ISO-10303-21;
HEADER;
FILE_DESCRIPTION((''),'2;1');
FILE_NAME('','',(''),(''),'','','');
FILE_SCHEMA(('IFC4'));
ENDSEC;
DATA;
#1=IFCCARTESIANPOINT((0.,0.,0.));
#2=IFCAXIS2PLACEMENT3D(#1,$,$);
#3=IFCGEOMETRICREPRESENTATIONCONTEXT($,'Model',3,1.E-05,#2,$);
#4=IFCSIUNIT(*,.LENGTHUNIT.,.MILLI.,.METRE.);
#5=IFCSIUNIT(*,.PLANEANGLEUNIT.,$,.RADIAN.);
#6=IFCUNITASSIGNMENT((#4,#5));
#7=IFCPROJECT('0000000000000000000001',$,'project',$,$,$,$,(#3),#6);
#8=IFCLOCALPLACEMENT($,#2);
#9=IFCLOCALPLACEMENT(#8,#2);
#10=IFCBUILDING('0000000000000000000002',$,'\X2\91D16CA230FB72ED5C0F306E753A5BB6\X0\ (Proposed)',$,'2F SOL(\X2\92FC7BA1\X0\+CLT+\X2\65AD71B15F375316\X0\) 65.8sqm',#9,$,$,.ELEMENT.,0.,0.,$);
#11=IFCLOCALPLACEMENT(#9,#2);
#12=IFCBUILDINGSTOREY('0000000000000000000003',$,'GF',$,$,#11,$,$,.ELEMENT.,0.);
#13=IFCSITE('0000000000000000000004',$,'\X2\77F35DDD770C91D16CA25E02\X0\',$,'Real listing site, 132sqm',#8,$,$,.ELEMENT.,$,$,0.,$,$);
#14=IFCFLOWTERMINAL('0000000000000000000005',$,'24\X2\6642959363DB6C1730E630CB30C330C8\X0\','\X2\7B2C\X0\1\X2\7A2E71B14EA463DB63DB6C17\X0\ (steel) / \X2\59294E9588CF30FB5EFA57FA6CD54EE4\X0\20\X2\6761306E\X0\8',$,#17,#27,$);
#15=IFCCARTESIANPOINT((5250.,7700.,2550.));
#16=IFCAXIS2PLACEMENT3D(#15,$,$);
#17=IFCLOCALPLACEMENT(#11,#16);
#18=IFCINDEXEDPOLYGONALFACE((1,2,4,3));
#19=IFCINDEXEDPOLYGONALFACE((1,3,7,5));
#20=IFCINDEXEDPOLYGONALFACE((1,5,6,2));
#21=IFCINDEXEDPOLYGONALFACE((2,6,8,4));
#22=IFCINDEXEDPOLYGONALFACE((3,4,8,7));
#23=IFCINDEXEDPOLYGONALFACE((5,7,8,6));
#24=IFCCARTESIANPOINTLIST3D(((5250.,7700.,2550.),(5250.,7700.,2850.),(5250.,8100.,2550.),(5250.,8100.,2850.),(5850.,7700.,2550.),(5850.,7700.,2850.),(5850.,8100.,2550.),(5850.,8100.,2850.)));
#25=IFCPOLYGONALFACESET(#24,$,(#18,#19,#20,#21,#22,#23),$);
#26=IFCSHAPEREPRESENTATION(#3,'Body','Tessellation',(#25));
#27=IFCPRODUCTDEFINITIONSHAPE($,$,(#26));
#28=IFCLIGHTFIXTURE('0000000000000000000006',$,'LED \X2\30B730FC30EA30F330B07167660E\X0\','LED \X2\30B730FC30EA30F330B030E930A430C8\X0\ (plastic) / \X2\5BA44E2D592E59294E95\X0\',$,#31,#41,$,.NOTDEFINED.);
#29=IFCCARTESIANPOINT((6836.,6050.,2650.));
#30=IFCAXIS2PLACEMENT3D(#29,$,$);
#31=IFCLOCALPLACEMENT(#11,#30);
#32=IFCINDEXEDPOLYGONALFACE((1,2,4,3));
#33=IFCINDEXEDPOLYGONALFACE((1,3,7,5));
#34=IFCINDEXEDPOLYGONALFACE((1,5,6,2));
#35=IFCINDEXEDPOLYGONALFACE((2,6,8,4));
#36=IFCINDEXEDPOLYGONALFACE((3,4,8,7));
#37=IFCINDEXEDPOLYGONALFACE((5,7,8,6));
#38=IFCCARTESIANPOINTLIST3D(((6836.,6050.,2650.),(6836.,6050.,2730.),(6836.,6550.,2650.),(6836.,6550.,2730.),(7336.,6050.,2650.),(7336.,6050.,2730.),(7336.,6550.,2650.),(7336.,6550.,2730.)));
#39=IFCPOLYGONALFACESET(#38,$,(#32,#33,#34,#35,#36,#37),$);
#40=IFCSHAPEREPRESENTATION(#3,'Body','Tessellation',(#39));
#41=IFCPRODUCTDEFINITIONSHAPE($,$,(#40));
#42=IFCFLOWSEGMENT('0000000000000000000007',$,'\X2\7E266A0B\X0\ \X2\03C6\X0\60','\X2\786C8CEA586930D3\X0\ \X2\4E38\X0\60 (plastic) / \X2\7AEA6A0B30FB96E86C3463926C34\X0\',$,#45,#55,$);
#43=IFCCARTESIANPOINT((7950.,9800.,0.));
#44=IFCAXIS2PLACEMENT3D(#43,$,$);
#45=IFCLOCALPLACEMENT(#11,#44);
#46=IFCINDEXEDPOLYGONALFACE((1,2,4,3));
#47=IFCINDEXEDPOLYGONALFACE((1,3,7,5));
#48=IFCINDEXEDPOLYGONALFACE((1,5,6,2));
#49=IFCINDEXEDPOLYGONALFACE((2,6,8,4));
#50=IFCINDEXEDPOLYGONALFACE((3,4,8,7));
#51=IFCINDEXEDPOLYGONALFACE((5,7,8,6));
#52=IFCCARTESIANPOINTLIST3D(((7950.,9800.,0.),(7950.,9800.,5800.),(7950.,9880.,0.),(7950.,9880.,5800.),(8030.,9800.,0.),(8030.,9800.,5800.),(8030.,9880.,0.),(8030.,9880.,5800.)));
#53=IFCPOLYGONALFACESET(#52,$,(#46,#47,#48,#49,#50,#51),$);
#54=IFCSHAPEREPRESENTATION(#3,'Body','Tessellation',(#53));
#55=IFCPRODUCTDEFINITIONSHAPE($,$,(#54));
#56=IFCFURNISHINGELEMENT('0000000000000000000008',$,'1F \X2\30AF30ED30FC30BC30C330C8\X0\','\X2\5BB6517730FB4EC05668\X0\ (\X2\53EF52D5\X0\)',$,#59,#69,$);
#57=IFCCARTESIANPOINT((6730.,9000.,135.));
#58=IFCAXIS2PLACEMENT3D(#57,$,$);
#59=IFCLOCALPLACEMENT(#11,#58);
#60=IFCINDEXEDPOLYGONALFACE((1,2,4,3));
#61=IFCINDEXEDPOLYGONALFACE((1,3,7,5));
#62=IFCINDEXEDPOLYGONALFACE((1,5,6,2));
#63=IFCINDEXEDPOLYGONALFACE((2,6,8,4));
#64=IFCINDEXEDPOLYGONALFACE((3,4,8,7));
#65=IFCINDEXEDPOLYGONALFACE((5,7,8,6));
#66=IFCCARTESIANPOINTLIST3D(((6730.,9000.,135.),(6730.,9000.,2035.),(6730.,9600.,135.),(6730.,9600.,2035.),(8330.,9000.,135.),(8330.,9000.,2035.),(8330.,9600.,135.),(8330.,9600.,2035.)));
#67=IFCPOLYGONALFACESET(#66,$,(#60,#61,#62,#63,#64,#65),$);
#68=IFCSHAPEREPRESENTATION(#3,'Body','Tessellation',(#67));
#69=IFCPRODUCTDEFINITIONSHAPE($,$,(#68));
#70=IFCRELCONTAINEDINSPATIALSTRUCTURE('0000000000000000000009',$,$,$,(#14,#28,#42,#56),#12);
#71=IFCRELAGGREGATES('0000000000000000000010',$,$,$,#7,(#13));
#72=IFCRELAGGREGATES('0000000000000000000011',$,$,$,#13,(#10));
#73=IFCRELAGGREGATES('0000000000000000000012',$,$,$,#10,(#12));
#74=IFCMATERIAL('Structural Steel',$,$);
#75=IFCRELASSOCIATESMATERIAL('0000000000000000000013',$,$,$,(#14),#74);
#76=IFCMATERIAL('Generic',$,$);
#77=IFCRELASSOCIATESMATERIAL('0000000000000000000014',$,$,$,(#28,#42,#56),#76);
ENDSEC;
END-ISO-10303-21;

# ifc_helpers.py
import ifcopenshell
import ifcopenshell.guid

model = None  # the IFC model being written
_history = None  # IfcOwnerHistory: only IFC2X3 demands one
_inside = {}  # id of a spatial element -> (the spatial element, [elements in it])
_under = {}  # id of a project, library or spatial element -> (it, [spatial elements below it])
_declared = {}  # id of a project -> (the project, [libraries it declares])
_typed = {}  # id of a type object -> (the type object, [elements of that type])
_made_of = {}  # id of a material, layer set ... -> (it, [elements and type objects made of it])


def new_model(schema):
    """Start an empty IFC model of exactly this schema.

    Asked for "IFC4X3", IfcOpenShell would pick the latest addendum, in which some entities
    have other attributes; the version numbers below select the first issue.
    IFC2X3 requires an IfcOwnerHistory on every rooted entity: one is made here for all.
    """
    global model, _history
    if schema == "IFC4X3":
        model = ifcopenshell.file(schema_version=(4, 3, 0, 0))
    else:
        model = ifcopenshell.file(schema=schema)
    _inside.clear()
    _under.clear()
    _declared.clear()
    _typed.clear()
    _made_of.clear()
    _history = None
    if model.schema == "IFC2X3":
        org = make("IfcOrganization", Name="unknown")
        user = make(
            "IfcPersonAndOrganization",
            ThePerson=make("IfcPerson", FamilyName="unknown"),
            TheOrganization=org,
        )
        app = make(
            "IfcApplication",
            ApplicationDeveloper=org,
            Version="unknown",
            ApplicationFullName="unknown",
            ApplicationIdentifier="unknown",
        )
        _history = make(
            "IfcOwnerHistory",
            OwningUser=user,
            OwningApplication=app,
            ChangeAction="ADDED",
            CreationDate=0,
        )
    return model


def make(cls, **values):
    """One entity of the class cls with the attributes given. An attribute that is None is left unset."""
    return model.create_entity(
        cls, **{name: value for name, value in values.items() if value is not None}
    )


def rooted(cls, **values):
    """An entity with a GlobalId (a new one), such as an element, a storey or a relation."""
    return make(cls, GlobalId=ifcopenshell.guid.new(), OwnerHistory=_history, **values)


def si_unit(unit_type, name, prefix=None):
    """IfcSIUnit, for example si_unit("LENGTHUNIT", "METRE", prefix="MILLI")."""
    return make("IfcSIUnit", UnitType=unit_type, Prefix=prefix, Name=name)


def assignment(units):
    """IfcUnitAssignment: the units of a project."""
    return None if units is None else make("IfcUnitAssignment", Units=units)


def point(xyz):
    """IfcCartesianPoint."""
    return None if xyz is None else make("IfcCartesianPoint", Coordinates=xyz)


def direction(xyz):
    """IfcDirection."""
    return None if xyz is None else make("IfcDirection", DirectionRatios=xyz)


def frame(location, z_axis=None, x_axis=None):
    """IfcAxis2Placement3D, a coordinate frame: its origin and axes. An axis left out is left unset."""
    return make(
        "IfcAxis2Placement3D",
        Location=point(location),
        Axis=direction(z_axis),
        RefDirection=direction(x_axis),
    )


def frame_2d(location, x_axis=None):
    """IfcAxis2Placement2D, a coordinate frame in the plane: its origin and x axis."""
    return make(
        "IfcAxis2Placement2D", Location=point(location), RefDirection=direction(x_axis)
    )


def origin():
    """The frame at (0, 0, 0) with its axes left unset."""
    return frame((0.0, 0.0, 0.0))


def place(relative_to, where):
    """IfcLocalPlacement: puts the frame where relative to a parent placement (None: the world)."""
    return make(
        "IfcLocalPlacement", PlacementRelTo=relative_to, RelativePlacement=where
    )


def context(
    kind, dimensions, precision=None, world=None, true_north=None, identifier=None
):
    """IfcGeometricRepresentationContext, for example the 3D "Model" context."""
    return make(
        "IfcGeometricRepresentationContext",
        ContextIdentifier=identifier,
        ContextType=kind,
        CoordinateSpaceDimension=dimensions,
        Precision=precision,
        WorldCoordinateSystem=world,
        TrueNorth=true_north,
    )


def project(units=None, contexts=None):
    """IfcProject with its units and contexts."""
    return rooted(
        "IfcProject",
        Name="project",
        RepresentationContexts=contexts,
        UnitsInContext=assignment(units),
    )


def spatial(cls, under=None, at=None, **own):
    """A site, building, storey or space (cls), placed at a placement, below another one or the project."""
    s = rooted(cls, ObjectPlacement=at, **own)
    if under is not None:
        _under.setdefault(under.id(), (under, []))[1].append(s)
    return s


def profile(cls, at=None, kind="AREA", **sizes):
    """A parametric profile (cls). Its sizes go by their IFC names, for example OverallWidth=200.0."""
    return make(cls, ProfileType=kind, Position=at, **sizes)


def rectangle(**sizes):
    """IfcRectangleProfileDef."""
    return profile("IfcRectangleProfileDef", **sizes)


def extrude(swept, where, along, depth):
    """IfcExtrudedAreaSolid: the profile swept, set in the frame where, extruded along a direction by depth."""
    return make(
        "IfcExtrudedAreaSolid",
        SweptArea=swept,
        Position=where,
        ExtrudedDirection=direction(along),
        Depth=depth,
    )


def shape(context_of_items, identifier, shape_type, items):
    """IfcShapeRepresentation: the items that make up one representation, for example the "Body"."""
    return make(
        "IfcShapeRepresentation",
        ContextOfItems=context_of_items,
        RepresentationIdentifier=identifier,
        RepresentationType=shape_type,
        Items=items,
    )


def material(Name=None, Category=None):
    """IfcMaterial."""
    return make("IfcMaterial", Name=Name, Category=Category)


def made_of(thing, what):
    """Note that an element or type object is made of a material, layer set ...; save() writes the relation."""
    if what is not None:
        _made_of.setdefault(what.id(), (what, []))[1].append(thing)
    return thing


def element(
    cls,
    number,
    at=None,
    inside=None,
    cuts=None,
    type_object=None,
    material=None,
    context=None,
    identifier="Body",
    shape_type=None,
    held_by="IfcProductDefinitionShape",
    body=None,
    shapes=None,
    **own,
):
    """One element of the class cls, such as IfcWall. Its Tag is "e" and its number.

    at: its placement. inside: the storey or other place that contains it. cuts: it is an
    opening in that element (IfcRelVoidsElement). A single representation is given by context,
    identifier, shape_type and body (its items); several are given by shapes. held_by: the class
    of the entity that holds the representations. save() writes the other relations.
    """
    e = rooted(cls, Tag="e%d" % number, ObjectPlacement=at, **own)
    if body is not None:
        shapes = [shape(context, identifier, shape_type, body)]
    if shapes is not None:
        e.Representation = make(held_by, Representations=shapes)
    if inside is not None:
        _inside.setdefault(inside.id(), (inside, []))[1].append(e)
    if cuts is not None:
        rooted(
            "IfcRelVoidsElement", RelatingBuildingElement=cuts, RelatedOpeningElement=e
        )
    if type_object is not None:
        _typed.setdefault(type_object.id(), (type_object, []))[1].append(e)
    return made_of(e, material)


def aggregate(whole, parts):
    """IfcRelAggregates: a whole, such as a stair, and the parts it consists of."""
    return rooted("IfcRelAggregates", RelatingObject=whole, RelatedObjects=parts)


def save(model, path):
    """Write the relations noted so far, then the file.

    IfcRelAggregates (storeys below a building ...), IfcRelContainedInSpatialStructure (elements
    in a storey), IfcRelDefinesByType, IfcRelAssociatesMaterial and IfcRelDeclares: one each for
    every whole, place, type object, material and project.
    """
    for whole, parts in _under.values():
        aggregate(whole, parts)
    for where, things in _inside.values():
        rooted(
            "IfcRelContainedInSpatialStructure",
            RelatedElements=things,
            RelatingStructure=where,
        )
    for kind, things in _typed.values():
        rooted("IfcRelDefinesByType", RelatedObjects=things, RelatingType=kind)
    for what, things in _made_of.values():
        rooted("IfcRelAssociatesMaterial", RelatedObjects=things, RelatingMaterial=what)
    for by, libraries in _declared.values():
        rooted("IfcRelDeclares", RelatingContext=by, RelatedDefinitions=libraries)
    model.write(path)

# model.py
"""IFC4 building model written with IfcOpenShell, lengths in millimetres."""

from ifc_helpers import new_model, si_unit, frame, frame_2d, origin, place, context, project, spatial, rectangle, extrude, material, element, save


model = new_model("IFC4")

# Units and contexts
model_context = context("Model", 3, precision=1e-05, world=origin())
ifc_project = project(units=[si_unit("LENGTHUNIT", "METRE", prefix="MILLI"), si_unit("PLANEANGLEUNIT", "RADIAN")], contexts=[model_context])

# Site, building, storey
site_placement = place(None, origin())
site = spatial("IfcSite", under=ifc_project, at=site_placement, Name="石川県金沢市", ObjectType="Real listing site, 132sqm", CompositionType="ELEMENT", RefElevation=0.0)
building_placement = place(site_placement, origin())
building = spatial("IfcBuilding", under=site, at=building_placement, Name="金沢・狭小の町家 (Proposed)", ObjectType="2F SOL(鋼管+CLT+断熱強化) 65.8sqm", CompositionType="ELEMENT", ElevationOfRefHeight=0.0, ElevationOfTerrain=0.0)
storey_placement = place(building_placement, origin())
storey = spatial("IfcBuildingStorey", under=building, at=storey_placement, Name="GF", CompositionType="ELEMENT", Elevation=0.0)

# Shared definitions
ifc_material_1 = material(Name="Generic")

# Flow terminal
ifc_material_2 = material(Name="Structural Steel")
flow_terminal_placement = place(storey_placement, frame((5250.0, 7700.0, 2550.0)))
element("IfcFlowTerminal", 1, at=flow_terminal_placement, inside=storey, material=ifc_material_2, Name="24時間換気ユニット", Description="第1種熱交換換気 (steel) / 天井裏・建基法令20条の8", context=model_context, shape_type="SweptSolid", body=[
    extrude(rectangle(XDim=600.0, YDim=400.0, at=frame_2d((300.0, 200.0))), frame((5250.0, 7700.0, 2550.0)), (0.0, 0.0, 1.0), 300.0),
])

# Light fixture
light_fixture_placement = place(storey_placement, frame((6836.0, 6050.0, 2650.0)))
element("IfcLightFixture", 2, at=light_fixture_placement, inside=storey, material=ifc_material_1, Name="LED シーリング照明", Description="LED シーリングライト (plastic) / 室中央天井", PredefinedType="NOTDEFINED", context=model_context, shape_type="SweptSolid", body=[
    extrude(rectangle(XDim=500.0, YDim=500.0, at=frame_2d((250.0, 250.0))), frame((6836.0, 6050.0, 2650.0)), (0.0, 0.0, 1.0), 80.0),
])

# Flow segment
flow_segment_placement = place(storey_placement, frame((7950.0, 9800.0, 0.0)))
element("IfcFlowSegment", 3, at=flow_segment_placement, inside=storey, material=ifc_material_1, Name="縦樋 φ60", Description="硬質塩ビ 丸60 (plastic) / 竪樋・雨水排水", context=model_context, shape_type="SweptSolid", body=[
    extrude(rectangle(XDim=80.0, YDim=80.0, at=frame_2d((40.0, 40.0))), frame((7950.0, 9800.0, 0.0)), (0.0, 0.0, 1.0), 5800.0),
])

# Furnishing element
furnishing_placement = place(storey_placement, frame((6730.0, 9000.0, 135.0)))
element("IfcFurnishingElement", 4, at=furnishing_placement, inside=storey, material=ifc_material_1, Name="1F クローゼット", Description="家具・什器 (可動)", context=model_context, shape_type="SweptSolid", body=[
    extrude(rectangle(XDim=1600.0, YDim=600.0, at=frame_2d((800.0, 300.0))), frame((6730.0, 9000.0, 135.0)), (0.0, 0.0, 1.0), 1900.0),
])

save(model, "model.ifc")
